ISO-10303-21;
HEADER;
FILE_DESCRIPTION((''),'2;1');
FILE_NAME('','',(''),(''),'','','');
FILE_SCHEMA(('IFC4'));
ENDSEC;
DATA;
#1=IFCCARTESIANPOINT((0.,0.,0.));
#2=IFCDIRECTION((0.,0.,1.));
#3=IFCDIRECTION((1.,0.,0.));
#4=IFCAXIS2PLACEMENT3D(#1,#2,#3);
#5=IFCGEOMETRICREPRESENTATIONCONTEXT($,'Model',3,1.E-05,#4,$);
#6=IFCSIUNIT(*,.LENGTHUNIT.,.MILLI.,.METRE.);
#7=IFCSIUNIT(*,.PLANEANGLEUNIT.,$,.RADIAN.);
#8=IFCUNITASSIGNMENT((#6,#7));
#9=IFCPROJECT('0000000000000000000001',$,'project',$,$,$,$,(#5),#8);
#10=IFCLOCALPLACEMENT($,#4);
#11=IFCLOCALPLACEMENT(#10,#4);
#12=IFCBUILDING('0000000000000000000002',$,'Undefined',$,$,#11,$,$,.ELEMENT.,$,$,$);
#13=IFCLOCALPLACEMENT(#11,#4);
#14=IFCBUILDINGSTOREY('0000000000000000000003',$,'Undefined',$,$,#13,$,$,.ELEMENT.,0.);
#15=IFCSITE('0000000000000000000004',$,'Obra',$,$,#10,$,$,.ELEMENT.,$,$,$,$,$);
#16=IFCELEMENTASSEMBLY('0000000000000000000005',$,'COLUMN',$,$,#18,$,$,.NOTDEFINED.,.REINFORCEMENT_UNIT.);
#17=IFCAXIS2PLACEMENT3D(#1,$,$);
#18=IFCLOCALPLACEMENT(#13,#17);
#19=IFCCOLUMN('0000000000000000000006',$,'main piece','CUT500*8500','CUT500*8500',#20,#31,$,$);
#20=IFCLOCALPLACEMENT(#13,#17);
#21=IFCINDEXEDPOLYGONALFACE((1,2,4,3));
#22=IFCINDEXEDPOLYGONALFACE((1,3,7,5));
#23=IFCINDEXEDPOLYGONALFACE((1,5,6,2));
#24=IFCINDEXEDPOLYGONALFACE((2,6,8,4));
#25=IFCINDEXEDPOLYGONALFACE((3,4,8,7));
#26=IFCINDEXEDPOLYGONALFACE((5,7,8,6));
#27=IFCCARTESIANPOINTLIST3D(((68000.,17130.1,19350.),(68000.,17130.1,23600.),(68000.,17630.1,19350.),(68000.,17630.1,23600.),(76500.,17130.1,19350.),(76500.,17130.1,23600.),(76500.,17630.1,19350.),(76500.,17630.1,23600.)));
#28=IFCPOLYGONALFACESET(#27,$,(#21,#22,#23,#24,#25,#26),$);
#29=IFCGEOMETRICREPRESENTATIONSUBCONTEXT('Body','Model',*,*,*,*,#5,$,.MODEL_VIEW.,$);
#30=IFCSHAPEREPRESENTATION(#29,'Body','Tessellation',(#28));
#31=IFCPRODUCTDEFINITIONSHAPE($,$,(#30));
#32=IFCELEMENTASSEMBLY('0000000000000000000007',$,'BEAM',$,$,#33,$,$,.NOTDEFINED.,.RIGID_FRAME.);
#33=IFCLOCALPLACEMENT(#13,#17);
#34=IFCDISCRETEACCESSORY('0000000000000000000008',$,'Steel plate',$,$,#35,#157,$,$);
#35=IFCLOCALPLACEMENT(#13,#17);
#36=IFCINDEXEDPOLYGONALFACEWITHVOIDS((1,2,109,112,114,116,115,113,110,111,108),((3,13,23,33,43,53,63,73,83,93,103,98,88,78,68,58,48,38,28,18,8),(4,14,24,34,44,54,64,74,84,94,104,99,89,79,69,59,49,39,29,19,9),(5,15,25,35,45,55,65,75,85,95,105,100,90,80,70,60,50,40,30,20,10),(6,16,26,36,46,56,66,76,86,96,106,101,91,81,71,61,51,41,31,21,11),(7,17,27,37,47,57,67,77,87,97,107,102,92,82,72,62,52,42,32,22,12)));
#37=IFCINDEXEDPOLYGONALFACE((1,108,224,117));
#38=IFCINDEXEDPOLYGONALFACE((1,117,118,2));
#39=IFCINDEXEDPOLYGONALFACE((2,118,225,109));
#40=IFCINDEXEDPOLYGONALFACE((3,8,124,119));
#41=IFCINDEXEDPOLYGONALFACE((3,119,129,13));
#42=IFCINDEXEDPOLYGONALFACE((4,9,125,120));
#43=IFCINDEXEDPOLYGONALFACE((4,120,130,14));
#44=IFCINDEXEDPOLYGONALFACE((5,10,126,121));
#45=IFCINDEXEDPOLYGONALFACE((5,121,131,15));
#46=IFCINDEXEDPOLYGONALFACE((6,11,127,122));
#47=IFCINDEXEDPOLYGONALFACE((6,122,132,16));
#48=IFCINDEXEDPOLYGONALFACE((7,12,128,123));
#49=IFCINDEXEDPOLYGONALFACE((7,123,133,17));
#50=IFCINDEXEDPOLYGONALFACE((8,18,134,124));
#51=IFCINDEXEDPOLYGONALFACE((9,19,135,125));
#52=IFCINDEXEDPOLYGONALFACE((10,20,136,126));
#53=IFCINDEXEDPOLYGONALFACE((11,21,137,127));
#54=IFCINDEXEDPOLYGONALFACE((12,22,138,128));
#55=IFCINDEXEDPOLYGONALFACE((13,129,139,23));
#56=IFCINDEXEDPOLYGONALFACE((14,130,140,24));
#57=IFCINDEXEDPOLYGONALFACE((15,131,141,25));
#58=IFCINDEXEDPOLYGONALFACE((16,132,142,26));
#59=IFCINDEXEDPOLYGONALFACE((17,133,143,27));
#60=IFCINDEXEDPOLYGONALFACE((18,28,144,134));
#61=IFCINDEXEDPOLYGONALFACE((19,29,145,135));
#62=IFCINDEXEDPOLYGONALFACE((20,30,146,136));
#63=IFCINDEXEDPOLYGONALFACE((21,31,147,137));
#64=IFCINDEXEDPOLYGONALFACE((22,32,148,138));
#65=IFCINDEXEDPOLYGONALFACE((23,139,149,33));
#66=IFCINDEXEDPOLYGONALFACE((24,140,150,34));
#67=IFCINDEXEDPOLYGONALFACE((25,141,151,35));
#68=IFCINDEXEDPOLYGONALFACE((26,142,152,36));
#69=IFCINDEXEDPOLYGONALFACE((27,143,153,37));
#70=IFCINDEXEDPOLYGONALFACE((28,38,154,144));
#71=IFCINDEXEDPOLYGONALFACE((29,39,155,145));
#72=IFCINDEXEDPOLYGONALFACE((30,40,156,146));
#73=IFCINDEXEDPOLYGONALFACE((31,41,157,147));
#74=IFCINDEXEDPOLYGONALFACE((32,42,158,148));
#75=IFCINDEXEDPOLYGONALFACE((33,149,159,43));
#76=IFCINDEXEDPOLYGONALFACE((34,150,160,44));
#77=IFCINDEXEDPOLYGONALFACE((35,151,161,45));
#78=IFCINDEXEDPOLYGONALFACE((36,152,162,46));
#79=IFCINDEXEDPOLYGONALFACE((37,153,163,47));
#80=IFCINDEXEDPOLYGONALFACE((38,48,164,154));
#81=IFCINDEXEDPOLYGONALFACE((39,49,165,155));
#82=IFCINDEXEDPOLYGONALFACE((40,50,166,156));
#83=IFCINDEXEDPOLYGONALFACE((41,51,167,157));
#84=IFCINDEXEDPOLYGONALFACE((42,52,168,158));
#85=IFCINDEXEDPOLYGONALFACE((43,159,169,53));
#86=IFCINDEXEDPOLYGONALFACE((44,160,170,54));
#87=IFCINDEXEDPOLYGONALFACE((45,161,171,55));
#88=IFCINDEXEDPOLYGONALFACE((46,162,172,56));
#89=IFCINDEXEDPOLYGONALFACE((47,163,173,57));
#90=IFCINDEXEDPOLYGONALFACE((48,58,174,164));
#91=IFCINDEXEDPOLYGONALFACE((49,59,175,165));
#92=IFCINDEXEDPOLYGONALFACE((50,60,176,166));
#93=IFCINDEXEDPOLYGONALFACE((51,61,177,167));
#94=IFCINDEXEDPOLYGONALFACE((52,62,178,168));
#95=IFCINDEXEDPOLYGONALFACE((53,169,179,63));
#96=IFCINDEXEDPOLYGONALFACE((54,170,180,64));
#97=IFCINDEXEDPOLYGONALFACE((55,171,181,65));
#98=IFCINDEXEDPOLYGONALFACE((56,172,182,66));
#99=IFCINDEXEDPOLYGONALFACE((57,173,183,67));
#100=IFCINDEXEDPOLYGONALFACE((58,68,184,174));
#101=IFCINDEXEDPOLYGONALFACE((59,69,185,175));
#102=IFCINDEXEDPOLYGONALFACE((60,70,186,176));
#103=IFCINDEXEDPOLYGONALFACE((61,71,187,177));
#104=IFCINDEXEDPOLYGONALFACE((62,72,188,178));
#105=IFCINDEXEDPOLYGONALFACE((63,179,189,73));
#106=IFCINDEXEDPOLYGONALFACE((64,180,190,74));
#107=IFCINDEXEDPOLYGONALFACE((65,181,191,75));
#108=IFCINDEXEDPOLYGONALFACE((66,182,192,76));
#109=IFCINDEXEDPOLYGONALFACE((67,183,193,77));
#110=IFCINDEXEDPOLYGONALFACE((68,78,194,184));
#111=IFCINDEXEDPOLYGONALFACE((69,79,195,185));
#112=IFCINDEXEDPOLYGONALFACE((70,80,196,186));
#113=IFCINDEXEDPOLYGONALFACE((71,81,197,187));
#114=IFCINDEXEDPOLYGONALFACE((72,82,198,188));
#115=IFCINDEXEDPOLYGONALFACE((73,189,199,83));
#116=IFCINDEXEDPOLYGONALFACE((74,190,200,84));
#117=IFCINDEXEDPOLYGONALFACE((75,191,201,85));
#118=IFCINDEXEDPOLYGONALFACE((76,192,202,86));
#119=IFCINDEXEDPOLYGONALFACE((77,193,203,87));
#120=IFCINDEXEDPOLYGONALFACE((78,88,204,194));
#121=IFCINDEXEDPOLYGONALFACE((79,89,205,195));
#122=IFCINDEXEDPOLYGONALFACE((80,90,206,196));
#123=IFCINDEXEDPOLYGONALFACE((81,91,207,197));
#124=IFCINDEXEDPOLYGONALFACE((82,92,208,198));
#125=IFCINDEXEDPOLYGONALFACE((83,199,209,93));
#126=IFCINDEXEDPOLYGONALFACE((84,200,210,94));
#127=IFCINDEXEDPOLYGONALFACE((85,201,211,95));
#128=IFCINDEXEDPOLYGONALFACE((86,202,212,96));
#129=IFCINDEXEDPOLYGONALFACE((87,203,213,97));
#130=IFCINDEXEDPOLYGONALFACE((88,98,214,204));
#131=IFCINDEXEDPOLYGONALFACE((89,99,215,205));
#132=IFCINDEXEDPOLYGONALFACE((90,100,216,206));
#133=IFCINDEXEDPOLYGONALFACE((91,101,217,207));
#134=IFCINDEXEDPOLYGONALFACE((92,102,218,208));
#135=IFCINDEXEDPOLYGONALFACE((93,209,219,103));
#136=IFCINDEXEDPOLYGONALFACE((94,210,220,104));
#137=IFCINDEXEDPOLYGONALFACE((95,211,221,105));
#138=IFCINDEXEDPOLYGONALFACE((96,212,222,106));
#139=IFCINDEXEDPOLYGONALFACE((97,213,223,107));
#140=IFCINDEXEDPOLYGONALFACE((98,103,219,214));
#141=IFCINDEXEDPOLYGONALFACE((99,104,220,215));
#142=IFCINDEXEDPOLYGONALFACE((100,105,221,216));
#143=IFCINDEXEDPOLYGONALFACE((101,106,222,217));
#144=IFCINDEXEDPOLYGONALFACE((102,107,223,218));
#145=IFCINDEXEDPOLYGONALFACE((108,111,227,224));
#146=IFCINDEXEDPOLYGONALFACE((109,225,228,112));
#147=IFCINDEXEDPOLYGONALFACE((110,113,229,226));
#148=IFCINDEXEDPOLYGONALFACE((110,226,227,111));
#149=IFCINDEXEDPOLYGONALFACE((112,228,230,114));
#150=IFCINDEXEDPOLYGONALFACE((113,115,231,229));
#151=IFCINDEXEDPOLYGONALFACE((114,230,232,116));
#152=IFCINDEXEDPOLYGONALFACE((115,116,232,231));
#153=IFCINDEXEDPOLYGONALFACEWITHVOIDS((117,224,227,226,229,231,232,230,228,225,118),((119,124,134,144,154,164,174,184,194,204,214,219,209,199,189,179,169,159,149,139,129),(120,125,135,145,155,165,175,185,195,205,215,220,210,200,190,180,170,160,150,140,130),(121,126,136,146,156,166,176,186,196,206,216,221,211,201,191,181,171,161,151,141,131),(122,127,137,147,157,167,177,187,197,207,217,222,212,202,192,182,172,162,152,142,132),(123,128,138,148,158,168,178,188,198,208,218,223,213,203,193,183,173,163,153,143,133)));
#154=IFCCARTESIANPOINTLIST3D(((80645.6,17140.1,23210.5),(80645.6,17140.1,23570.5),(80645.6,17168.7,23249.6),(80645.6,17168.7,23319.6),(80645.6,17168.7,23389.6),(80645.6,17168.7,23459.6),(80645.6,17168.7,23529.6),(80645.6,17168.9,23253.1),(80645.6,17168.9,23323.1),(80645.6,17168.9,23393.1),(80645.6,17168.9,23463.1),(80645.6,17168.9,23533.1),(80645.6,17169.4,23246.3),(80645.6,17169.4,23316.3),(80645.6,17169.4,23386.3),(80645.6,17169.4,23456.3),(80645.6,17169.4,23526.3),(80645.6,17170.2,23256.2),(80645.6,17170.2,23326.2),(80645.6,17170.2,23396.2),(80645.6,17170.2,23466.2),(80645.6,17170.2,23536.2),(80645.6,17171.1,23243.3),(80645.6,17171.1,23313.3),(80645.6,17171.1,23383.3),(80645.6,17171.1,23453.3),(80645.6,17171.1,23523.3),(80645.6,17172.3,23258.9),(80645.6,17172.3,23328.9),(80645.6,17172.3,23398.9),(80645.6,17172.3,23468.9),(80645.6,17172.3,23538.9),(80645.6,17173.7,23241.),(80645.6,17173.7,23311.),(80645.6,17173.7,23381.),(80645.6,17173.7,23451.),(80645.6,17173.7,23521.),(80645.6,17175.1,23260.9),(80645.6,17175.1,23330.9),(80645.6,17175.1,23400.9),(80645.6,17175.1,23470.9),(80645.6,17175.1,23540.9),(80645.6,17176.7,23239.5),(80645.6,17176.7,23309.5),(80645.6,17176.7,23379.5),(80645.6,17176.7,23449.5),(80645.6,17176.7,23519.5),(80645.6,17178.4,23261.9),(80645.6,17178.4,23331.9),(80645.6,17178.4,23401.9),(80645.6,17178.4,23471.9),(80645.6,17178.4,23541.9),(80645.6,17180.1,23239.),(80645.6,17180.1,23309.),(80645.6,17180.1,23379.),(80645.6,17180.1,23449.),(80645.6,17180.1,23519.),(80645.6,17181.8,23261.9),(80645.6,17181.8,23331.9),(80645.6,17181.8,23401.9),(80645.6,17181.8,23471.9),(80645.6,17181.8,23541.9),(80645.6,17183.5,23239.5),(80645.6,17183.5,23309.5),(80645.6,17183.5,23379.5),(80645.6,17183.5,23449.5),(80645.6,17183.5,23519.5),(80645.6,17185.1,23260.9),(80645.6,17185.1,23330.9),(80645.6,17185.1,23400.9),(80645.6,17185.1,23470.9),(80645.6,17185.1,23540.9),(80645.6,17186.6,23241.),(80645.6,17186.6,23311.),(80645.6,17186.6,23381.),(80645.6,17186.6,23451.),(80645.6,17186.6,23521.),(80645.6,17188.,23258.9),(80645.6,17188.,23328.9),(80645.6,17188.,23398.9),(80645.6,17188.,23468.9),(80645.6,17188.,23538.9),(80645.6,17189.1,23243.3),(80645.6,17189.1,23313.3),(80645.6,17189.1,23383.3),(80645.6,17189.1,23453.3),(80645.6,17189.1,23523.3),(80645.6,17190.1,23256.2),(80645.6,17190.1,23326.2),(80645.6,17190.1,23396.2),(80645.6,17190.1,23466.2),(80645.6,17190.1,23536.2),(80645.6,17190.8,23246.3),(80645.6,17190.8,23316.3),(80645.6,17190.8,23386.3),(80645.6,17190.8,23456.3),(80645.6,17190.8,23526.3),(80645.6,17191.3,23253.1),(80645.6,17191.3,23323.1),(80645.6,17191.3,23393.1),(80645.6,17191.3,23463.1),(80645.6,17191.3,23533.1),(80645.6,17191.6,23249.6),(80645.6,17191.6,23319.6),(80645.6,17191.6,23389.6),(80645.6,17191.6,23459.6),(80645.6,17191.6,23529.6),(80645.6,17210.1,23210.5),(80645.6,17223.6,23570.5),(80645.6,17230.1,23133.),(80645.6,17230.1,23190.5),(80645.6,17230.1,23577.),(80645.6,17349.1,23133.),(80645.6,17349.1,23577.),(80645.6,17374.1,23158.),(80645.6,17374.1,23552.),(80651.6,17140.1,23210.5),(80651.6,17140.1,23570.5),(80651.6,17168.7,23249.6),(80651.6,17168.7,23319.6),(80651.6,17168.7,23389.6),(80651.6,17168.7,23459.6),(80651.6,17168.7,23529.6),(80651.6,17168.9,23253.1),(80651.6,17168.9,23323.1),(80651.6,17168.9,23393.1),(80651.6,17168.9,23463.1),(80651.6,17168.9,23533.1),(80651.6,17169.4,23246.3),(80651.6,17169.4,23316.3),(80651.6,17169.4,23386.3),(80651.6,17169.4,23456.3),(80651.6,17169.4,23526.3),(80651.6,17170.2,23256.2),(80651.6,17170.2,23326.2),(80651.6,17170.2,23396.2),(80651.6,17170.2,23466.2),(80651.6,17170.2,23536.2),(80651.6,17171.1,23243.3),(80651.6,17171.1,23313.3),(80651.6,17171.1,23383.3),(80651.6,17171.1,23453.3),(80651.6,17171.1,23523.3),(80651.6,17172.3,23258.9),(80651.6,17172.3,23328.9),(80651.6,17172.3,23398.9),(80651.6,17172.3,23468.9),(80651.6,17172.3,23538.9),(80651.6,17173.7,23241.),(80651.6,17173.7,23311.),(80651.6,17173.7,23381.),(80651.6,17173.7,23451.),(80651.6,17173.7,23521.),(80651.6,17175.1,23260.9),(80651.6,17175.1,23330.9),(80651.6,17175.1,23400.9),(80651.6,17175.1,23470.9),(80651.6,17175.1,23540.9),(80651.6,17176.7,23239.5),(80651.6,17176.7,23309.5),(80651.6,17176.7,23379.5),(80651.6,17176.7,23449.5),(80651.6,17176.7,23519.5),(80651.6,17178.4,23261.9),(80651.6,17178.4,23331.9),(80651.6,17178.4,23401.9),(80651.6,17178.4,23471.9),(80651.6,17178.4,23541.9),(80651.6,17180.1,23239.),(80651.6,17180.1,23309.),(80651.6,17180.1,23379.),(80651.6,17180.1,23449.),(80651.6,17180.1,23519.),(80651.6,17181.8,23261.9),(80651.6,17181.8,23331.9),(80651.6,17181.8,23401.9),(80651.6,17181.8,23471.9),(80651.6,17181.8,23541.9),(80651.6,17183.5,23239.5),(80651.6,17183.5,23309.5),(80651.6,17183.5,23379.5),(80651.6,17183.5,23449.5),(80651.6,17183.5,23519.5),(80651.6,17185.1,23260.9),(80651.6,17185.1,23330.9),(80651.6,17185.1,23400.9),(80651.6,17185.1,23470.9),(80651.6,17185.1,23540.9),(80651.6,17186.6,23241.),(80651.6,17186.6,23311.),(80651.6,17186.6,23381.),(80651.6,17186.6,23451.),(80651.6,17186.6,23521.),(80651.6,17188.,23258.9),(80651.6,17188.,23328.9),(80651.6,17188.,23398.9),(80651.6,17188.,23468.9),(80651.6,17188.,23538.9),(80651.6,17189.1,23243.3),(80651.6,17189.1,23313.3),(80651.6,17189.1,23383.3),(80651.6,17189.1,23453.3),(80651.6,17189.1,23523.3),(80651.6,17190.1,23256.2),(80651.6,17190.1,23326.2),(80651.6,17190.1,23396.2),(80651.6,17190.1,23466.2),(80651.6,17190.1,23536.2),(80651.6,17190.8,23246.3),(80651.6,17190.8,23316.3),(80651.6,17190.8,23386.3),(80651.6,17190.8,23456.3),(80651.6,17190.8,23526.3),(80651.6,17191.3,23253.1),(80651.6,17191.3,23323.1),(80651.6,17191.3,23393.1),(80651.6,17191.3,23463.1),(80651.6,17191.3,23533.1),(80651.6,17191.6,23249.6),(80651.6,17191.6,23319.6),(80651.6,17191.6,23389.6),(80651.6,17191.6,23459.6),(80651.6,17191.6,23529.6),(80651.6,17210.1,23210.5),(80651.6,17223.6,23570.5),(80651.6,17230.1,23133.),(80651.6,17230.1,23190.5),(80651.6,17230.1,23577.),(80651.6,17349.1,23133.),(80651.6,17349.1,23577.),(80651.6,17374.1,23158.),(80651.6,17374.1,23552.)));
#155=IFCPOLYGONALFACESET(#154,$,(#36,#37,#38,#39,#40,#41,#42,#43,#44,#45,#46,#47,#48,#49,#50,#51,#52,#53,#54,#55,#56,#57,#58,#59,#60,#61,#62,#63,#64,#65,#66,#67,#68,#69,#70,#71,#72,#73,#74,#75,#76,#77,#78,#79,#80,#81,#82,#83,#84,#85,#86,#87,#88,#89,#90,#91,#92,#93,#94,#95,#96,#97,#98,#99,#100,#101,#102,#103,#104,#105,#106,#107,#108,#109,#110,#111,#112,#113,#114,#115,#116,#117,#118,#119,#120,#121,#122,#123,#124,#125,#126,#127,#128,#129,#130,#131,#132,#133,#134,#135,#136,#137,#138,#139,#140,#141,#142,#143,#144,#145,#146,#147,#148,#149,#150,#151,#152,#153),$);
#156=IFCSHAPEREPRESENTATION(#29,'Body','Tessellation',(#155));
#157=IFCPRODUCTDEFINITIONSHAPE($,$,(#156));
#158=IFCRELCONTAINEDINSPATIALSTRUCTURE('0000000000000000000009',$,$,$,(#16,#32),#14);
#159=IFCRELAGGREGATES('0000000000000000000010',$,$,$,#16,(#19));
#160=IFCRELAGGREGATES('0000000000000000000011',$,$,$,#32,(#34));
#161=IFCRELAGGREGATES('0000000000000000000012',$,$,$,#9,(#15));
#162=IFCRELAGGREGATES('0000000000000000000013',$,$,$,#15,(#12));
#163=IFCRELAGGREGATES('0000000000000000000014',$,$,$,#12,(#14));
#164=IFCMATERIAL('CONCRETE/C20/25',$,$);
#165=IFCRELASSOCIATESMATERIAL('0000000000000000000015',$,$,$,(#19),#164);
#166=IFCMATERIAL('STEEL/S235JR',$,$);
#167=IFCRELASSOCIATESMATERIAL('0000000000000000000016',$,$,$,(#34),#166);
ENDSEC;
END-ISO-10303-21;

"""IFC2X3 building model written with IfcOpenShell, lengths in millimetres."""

from ifc_helpers import new_model, si_unit, frame, origin_with_axes, origin_2d_with_axis, place, context, subcontext, project, spatial, polyline, rectangle, circle, outline, extrude, source, transform, mapped, material, element, aggregate, save


model = new_model("IFC2X3")

# Units and contexts
model_context = context("Model", 3, precision=1e-05, world=origin_with_axes())
body_context = subcontext(model_context, "Body", "Model", "MODEL_VIEW")
ifc_project = project(units=[si_unit("LENGTHUNIT", "METRE", prefix="MILLI"), si_unit("PLANEANGLEUNIT", "RADIAN")], contexts=[model_context])

# Site, building, storey
site_placement = place(None, origin_with_axes())
site = spatial("IfcSite", under=ifc_project, at=site_placement, Name="Obra", CompositionType="ELEMENT")
building_placement = place(site_placement, origin_with_axes())
building = spatial("IfcBuilding", under=site, at=building_placement, Name="Undefined", CompositionType="ELEMENT")
storey_placement = place(building_placement, origin_with_axes())
storey = spatial("IfcBuildingStorey", under=building, at=storey_placement, Name="Undefined", CompositionType="ELEMENT", Elevation=0.0)

# Element assembly, column
assembly_1_placement = place(storey_placement, origin_with_axes())
assembly_1 = element("IfcElementAssembly", 1, at=assembly_1_placement, inside=storey, Name="COLUMN", AssemblyPlace="NOTDEFINED", PredefinedType="REINFORCEMENT_UNIT")
ifc_material_1 = material(Name="CONCRETE/C20/25")
column_placement = place(assembly_1_placement, frame((72250.0, 17380.1, 19350.0), z_axis=(0.0, 0.0, 1.0), x_axis=(-1.0, 0.0, 0.0)))
column = element("IfcColumn", 2, at=column_placement, material=ifc_material_1, Name="main piece", Description="CUT500*8500", ObjectType="CUT500*8500", context=body_context, shape_type="SweptSolid", body=[
    extrude(rectangle(XDim=500.0, YDim=8500.0, at=origin_2d_with_axis()), frame((0.0, 0.0, 4250.0), z_axis=(0.0, 0.0, -1.0), x_axis=(0.0, 1.0, 0.0)), (0.0, 0.0, 1.0), 4250.0),
])
aggregate(assembly_1, [column])

# Element assembly, discrete accessory, opening
assembly_2_placement = place(storey_placement, origin_with_axes())
assembly_2 = element("IfcElementAssembly", 3, at=assembly_2_placement, inside=storey, Name="BEAM", AssemblyPlace="NOTDEFINED", PredefinedType="RIGID_FRAME")
ifc_material_2 = material(Name="STEEL/S235JR")
discrete_accessory_1_placement = place(assembly_2_placement, frame((80648.6, 17374.1, 23158.0), z_axis=(-1.0, 0.0, 0.0), x_axis=(0.0, -0.707107, -0.707107)))
discrete_accessory_1 = element("IfcDiscreteAccessory", 4, at=discrete_accessory_1_placement, material=ifc_material_2, Name="Steel plate", context=body_context, shape_type="SweptSolid", body=[
    extrude(outline(polyline([(0.0, 0.0), (35.4, 0.0), (119.5, 84.1), (78.8, 124.8), (78.8, 153.1), (128.3, 202.6), (-126.2, 457.1), (-185.3, 398.1), (-194.5, 398.1), (-194.5, 398.1), (-278.6, 314.0), (-278.6, 278.6), (0.0, 0.0)])), frame((0.0, 0.0, -3.0), z_axis=(0.0, 0.0, 1.0), x_axis=(1.0, 0.0, 0.0)), (0.0, 0.0, 1.0), 6.0),
])
shared_shape_1 = source(origin_with_axes(), body_context, "Body", "SweptSolid", [
    extrude(circle(Radius=11.5, at=origin_2d_with_axis()), frame((0.0, 3.6, 0.0), z_axis=(0.0, 1.0, 0.0), x_axis=(1.0, 0.0, 0.0)), (0.0, 0.0, 1.0), 6.2),
])
opening_1_placement = place(assembly_2_placement, frame((80641.9, 17220.1, 23570.5), z_axis=(0.0, -1.0, 0.0), x_axis=(0.0, 0.0, -1.0)))
element("IfcOpeningElement", 5, at=opening_1_placement, cuts=discrete_accessory_1, ObjectType="Opening", context=body_context, shape_type="MappedRepresentation", body=[
    mapped(shared_shape_1, transform((40.0, 0.0, 40.0))),
    mapped(shared_shape_1, transform((110.0, 0.0, 40.0))),
    mapped(shared_shape_1, transform((180.0, 0.0, 40.0))),
    mapped(shared_shape_1, transform((250.0, 0.0, 40.0))),
    mapped(shared_shape_1, transform((320.0, 0.0, 40.0))),
])

aggregate(assembly_2, [discrete_accessory_1])

save(model, "model.ifc")
